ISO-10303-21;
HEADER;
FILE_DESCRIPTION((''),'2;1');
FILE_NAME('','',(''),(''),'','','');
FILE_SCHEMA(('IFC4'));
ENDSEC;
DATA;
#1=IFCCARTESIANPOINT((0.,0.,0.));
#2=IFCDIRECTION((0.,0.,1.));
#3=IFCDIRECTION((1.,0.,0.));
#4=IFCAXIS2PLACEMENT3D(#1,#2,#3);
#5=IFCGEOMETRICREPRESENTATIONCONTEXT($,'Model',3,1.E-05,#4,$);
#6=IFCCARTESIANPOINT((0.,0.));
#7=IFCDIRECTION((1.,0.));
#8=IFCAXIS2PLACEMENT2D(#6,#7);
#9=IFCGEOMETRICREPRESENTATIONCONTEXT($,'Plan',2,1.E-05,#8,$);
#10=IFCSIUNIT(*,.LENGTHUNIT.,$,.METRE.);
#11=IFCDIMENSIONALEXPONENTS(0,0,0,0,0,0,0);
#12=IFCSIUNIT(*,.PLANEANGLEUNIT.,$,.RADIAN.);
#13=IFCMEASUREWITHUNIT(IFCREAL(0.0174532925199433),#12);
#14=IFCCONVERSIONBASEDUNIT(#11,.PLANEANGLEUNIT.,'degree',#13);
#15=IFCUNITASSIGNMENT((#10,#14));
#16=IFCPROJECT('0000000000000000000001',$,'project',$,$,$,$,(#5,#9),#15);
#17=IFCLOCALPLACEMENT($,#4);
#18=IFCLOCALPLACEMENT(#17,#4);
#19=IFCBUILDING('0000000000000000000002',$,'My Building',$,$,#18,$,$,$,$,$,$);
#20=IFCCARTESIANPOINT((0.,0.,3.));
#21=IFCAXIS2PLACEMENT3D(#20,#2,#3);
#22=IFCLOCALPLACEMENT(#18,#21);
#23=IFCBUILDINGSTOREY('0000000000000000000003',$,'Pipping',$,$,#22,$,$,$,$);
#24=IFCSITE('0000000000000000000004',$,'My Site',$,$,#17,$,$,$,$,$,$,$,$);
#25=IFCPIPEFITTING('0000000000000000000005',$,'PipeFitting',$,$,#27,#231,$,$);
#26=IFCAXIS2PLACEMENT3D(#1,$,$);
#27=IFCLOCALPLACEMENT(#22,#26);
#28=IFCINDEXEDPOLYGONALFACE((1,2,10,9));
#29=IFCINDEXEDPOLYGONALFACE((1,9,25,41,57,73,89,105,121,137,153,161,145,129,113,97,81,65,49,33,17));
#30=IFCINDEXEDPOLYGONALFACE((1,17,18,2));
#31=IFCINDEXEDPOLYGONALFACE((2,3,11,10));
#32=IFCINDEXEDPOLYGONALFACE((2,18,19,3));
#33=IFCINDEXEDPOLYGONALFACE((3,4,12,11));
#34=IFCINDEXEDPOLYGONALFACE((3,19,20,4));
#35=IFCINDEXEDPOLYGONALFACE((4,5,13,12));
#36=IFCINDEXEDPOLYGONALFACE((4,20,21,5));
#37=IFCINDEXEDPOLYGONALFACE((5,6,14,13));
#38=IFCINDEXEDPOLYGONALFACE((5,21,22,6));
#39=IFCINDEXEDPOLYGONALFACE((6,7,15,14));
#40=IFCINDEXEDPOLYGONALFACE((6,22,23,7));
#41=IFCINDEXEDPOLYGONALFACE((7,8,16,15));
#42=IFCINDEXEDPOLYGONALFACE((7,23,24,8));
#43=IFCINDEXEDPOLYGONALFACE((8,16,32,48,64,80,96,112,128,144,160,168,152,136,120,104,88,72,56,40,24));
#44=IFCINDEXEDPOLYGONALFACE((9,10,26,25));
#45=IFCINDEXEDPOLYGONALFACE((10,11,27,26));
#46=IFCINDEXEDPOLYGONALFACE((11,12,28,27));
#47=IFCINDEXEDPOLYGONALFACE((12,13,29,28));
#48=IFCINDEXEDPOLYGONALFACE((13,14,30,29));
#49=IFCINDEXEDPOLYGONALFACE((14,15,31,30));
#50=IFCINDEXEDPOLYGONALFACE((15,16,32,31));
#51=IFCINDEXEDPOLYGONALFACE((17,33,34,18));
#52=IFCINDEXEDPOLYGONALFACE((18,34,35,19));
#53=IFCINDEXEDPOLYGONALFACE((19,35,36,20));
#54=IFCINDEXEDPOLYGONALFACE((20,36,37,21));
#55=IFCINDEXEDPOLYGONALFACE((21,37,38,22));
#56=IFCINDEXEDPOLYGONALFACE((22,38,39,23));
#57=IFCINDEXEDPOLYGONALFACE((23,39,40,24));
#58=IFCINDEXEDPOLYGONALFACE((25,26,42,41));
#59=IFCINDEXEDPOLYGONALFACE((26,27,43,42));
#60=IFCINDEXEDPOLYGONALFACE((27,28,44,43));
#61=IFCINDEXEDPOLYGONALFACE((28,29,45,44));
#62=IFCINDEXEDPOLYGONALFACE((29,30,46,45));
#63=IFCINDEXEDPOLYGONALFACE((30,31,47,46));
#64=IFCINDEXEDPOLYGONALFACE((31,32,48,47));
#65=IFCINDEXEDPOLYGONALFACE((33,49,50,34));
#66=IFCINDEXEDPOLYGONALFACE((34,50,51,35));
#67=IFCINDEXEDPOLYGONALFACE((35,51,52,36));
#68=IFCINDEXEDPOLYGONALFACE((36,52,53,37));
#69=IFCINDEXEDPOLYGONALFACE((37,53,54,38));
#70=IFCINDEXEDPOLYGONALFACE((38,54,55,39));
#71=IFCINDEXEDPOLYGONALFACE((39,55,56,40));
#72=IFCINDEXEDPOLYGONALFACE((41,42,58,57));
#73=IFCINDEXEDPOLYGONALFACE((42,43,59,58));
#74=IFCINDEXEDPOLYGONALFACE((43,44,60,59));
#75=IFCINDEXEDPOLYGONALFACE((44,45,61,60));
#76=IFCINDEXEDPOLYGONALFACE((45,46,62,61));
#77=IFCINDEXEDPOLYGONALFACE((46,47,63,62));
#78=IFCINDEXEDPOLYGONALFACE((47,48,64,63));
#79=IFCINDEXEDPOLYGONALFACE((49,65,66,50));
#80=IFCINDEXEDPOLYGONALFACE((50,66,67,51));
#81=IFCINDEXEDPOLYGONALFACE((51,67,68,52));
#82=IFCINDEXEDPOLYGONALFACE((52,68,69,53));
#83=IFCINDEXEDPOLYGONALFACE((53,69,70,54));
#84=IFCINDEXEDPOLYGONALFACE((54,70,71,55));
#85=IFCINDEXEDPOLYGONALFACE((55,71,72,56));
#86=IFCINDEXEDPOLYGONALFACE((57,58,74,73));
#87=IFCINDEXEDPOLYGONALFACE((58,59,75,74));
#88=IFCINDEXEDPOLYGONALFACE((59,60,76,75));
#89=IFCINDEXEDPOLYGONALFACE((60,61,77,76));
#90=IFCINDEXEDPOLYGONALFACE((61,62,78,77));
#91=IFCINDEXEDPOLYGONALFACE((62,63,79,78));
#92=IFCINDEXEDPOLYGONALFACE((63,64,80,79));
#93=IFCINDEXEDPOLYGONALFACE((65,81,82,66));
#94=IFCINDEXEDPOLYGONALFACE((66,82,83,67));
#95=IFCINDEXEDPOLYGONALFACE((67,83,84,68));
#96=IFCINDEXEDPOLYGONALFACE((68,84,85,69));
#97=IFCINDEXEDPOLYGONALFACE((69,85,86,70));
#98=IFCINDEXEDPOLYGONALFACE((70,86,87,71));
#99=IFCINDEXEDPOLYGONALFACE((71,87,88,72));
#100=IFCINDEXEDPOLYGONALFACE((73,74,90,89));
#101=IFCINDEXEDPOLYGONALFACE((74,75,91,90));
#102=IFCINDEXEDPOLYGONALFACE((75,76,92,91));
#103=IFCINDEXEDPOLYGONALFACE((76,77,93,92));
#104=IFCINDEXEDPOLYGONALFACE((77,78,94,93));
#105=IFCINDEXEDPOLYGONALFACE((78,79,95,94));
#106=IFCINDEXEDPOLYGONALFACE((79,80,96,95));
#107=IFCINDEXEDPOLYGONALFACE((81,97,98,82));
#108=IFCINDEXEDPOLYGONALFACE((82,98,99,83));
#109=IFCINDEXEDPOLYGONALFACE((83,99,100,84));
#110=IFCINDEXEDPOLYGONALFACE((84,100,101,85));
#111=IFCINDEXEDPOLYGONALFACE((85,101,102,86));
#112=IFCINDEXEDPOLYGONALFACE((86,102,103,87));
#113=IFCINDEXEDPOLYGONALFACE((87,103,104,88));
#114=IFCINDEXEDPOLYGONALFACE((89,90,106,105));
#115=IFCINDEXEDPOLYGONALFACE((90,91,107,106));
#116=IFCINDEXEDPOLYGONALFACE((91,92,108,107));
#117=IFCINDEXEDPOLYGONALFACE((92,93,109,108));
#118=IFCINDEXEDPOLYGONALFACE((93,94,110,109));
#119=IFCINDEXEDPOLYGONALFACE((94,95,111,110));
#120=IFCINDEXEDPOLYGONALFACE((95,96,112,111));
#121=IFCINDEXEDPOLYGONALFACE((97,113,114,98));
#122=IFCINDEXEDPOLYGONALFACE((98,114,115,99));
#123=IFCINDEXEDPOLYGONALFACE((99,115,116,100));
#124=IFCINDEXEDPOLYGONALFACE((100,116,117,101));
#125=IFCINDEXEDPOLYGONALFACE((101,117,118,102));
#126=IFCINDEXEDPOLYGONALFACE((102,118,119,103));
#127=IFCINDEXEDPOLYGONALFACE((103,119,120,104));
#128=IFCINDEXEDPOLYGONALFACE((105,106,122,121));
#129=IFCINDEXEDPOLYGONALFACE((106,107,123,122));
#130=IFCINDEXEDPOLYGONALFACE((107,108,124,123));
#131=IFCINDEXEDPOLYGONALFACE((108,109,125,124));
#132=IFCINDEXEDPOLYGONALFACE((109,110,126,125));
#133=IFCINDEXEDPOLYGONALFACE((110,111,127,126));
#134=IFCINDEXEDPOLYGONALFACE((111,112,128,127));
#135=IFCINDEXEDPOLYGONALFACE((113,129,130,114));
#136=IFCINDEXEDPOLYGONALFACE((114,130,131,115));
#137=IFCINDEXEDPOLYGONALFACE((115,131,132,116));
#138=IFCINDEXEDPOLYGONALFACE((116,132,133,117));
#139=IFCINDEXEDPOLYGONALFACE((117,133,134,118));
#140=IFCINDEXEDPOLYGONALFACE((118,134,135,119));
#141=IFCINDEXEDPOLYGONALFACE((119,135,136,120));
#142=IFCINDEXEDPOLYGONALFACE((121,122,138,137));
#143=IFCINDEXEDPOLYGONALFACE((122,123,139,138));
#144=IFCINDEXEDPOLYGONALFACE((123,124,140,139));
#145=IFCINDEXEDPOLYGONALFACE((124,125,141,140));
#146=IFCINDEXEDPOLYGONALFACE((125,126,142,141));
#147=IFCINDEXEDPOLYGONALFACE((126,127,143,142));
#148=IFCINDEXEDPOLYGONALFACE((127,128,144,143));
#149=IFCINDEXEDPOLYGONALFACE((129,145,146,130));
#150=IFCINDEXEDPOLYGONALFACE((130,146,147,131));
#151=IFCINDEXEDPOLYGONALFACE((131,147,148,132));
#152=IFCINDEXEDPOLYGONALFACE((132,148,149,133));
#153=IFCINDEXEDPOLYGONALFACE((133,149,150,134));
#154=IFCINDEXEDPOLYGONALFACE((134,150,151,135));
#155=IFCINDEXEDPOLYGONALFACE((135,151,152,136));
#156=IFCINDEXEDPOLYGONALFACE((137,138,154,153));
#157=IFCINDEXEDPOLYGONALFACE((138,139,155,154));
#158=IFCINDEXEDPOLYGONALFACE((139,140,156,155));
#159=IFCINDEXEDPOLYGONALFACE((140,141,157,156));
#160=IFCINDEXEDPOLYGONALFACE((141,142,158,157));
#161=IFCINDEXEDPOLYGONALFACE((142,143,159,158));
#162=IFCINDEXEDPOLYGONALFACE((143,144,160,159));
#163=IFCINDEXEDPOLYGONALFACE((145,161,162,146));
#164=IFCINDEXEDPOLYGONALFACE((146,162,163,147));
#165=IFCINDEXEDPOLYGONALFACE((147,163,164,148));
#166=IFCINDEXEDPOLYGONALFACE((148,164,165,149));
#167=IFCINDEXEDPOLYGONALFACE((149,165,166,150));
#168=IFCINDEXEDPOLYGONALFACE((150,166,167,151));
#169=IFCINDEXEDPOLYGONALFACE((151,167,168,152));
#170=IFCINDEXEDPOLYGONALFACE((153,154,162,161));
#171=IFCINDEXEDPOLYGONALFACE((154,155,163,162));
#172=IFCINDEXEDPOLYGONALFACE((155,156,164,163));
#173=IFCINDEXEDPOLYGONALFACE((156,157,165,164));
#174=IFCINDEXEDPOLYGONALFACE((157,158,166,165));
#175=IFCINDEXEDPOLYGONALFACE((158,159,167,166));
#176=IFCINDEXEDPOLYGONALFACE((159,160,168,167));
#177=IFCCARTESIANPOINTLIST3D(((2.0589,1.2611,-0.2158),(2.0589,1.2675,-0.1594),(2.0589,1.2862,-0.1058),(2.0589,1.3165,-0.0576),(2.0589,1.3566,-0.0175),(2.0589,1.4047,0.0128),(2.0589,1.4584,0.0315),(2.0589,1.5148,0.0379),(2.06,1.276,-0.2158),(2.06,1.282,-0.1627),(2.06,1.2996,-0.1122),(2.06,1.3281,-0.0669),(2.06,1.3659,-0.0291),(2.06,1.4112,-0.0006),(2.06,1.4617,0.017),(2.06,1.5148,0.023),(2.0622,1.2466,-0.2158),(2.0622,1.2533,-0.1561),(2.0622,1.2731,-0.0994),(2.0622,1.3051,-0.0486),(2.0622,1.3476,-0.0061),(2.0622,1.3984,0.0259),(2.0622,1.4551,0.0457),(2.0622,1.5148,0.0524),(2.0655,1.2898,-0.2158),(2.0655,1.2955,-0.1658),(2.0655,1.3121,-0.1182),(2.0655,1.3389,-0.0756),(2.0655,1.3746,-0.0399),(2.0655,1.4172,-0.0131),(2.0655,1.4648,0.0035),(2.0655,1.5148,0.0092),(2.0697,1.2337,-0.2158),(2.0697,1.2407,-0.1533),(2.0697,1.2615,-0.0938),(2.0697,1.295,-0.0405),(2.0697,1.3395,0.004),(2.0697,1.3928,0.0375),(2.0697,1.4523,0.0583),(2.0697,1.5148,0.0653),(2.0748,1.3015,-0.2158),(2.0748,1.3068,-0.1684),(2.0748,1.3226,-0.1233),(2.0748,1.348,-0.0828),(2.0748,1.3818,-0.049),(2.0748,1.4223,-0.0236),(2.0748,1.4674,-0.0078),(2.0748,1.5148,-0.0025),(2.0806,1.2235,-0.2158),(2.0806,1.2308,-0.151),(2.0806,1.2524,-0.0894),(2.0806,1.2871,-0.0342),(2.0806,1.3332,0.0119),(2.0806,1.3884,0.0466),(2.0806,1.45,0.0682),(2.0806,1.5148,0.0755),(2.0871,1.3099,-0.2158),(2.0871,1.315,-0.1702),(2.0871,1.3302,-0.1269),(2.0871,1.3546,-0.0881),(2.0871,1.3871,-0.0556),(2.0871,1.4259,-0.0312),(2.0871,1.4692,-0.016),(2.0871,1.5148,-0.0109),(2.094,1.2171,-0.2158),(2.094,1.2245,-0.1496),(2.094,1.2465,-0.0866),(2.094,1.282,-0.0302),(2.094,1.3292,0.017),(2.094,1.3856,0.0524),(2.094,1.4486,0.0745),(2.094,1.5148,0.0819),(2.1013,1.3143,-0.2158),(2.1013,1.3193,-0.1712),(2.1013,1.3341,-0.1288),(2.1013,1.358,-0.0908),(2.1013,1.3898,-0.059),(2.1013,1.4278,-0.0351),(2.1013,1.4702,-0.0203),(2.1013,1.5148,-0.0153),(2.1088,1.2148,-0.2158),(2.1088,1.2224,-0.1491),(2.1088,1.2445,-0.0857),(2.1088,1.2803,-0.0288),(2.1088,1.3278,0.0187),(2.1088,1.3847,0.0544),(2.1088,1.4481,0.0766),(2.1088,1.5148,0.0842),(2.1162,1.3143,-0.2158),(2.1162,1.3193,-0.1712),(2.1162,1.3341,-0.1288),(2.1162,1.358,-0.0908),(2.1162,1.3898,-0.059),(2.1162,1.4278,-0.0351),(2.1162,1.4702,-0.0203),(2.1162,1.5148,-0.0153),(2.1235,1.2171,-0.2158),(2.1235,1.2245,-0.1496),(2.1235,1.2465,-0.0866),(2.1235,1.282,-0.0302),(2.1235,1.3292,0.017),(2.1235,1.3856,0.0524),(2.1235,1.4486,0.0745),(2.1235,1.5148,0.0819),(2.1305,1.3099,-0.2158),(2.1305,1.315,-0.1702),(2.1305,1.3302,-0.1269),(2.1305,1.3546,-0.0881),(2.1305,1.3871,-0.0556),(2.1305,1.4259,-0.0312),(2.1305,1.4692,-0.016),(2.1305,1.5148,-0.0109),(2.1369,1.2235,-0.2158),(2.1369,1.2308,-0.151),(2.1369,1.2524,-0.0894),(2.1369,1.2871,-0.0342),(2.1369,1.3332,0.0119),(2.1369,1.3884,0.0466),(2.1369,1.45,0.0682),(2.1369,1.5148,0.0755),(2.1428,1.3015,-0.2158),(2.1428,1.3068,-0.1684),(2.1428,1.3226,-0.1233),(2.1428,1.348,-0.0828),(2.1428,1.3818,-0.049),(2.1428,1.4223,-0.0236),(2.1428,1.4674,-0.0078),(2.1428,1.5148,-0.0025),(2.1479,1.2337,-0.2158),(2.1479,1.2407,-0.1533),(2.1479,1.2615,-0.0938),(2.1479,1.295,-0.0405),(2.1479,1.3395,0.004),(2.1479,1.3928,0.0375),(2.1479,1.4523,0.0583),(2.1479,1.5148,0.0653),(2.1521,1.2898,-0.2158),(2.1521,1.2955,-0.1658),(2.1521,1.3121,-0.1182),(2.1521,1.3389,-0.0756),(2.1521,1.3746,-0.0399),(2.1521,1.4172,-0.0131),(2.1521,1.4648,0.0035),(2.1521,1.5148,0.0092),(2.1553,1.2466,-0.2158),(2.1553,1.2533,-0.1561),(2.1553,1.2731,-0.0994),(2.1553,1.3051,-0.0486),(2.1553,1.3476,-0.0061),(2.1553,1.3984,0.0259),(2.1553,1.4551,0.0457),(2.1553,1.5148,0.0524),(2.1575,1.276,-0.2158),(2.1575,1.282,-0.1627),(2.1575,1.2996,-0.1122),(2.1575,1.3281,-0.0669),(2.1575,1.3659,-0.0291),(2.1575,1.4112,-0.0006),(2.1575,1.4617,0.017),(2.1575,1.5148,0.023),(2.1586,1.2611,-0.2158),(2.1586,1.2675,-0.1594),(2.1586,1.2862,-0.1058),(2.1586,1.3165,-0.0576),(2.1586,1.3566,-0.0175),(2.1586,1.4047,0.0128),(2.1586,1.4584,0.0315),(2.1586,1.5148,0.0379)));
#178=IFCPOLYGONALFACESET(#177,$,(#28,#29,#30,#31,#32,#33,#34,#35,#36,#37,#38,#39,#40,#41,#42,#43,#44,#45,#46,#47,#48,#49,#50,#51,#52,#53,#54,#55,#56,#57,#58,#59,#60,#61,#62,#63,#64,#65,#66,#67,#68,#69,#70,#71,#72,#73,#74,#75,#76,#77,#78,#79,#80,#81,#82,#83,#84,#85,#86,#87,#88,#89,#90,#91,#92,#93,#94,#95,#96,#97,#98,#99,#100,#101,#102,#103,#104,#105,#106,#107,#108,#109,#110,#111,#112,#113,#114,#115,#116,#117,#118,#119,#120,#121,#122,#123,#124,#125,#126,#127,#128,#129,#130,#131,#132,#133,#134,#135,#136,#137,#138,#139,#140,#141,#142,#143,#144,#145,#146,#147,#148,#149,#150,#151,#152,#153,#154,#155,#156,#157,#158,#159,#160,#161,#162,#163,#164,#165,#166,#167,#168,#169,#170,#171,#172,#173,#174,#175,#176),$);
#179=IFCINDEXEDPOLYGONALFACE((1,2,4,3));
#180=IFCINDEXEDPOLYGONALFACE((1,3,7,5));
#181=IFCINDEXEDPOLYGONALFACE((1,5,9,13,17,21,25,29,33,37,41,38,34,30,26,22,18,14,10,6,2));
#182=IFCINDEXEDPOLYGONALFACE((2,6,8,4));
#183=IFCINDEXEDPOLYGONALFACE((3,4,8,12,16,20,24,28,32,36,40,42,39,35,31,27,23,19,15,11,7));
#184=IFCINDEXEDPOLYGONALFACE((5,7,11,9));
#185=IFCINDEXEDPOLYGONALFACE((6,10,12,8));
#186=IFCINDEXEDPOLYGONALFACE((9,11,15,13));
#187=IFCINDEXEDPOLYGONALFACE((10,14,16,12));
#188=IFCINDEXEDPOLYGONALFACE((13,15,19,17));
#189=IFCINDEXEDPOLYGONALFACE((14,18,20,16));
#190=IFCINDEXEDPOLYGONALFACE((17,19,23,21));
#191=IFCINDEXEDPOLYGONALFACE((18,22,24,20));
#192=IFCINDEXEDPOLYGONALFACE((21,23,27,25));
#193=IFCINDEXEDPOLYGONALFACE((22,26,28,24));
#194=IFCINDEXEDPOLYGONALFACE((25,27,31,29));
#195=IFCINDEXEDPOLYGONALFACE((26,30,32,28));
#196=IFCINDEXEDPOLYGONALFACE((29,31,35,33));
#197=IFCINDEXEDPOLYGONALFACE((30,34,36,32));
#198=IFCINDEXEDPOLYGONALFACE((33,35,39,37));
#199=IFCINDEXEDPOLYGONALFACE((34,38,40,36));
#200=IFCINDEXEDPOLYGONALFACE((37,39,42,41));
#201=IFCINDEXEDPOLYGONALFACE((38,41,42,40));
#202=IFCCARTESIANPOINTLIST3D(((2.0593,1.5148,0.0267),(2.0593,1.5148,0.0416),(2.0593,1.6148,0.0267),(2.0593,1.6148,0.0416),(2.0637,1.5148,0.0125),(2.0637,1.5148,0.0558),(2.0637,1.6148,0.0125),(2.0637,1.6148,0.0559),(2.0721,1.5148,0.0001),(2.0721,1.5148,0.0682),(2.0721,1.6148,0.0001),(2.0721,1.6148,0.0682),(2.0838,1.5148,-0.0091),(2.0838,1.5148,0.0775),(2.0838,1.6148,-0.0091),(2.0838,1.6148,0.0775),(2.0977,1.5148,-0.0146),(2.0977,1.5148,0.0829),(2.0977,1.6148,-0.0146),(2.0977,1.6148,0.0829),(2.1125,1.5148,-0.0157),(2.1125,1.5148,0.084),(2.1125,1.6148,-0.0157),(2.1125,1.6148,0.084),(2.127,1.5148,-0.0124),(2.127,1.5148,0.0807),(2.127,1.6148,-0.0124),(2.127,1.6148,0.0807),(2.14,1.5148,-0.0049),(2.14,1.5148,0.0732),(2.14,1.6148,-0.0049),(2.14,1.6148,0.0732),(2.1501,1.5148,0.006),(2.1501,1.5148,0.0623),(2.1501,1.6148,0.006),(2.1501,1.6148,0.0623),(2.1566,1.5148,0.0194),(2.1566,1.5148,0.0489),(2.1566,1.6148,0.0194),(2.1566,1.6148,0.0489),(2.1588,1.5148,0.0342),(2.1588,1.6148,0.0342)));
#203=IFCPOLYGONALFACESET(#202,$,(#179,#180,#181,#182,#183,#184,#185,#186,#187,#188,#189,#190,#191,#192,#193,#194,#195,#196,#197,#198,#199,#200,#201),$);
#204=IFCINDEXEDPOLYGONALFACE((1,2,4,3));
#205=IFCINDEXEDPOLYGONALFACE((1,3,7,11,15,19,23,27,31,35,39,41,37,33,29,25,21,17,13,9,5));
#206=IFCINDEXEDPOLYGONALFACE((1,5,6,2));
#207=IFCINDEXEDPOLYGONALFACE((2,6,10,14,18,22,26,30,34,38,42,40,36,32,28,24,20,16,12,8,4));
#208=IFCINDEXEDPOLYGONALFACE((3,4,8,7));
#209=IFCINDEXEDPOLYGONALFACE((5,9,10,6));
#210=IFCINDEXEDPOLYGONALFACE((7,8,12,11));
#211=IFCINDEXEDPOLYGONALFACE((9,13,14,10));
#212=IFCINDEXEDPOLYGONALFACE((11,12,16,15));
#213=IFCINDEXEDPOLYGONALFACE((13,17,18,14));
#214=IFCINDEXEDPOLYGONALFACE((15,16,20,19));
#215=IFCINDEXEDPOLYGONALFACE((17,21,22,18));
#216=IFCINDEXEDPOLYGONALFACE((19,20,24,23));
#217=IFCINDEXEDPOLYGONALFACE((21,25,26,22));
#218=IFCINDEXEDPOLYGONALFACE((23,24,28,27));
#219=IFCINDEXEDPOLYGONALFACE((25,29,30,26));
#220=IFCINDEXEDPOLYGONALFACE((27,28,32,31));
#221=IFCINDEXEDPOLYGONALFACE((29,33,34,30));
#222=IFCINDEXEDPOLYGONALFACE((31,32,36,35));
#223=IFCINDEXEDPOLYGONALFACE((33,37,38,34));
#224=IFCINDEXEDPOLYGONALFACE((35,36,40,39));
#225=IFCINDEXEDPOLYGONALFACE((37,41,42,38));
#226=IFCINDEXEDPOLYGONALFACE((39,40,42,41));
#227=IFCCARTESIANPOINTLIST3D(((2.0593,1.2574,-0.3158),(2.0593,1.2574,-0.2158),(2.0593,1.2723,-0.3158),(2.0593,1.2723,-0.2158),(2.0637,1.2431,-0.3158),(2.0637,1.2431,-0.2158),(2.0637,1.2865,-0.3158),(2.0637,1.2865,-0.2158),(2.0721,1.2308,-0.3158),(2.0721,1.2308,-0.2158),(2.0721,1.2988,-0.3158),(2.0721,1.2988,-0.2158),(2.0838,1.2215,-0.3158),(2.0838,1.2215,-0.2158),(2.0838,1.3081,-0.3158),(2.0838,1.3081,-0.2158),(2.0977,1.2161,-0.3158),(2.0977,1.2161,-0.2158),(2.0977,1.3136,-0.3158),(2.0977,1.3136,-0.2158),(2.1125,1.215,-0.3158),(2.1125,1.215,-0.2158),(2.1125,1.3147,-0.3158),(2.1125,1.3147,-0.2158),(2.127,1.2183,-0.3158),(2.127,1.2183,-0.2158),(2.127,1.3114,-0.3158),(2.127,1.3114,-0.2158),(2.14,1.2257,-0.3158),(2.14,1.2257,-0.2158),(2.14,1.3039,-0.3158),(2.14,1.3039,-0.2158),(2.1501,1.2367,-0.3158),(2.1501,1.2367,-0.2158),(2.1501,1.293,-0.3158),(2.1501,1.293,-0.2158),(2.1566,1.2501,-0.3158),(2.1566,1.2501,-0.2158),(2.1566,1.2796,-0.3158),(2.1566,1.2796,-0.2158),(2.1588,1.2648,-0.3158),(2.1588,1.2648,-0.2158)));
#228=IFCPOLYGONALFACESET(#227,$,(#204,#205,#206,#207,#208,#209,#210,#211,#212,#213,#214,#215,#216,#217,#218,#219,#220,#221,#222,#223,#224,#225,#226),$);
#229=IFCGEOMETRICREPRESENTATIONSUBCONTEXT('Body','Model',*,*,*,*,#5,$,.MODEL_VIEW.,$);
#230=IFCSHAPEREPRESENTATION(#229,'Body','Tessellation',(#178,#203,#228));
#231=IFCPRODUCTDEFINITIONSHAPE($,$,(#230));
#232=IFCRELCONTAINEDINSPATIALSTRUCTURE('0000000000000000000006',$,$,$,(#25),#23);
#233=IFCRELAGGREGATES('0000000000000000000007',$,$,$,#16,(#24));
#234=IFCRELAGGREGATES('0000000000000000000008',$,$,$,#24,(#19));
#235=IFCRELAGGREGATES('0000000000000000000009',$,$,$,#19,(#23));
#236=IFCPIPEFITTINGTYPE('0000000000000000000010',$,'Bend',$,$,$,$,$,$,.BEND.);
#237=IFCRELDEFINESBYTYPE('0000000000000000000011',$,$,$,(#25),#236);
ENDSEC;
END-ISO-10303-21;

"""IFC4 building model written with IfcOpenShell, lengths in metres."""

from ifc_helpers import new_model, entity, si_unit, converted_unit, frame, origin_with_axes, origin_2d_with_axis, place, context, subcontext, project, spatial, circle, extrude, source, transform, mapped, type_object, type_shapes, element, save


model = new_model("IFC4")

# Units and contexts
model_context = context("Model", 3, precision=1e-05, world=origin_with_axes())
plan_context = context("Plan", 2, precision=1e-05, world=origin_2d_with_axis())
body_context = subcontext(model_context, "Body", "Model", "MODEL_VIEW")
ifc_project = project(units=[si_unit("LENGTHUNIT", "METRE"), converted_unit("PLANEANGLEUNIT", "degree", entity("IfcReal", 0.0174532925199433), si_unit("PLANEANGLEUNIT", "RADIAN"), dimensions=[0, 0, 0, 0, 0, 0, 0])], contexts=[model_context, plan_context])

# Site, building, storey
site_placement = place(None, origin_with_axes())
site = spatial("IfcSite", under=ifc_project, at=site_placement, Name="My Site")
building_placement = place(site_placement, origin_with_axes())
building = spatial("IfcBuilding", under=site, at=building_placement, Name="My Building")
storey_placement = place(building_placement, frame((0.0, 0.0, 3.0), z_axis=(0.0, 0.0, 1.0), x_axis=(1.0, 0.0, 0.0)))
storey = spatial("IfcBuildingStorey", under=building, at=storey_placement, Name="Pipping")

# Pipe fitting
pipe_fitting_type_1 = type_object("IfcPipeFittingType", Name="Bend", PredefinedType="BEND")
shared_shape_1 = source(origin_with_axes(), body_context, "Body", "SolidModel", [
    entity("IfcSweptDiskSolid", entity("IfcIndexedPolyCurve", entity("IfcCartesianPointList3D", [[0.0, 0.0, 0.1], [0.0, -0.0732, 0.2768], [0.0, -0.25, 0.35]]), [entity("IfcArcIndex", [1, 2, 3])]), 0.05),
    extrude(circle(Radius=0.05), origin_with_axes(), (0.0, 0.0, 1.0), 0.1),
    extrude(circle(Radius=0.05), frame((0.0, -0.25, 0.35), z_axis=(0.0, -1.0, 0.000004), x_axis=(1.0, 0.0, 0.0)), (0.0, 0.0, 1.0), 0.1),
])
type_shapes(pipe_fitting_type_1, [shared_shape_1])
for number, where, z_axis, x_axis, name in (
    (1, (2.1088, 1.6148, 0.0342), (0.0, -1.0, -0.000004), (1.0, 0.0, 0.0), "PipeFitting"),
):
    element("IfcPipeFitting", number, at=place(storey_placement, frame(where, z_axis=z_axis, x_axis=x_axis)), inside=storey, type_object=pipe_fitting_type_1, Name=name, context=body_context, shape_type="MappedRepresentation", body=[
        mapped(shared_shape_1, transform((0.0, 0.0, 0.0), x_axis=(1.0, 0.0, 0.0), y_axis=(0.0, 1.0, 0.0), z_axis=(0.0, 0.0, 1.0), scale=1.0)),
    ])

save(model, "model.ifc")
